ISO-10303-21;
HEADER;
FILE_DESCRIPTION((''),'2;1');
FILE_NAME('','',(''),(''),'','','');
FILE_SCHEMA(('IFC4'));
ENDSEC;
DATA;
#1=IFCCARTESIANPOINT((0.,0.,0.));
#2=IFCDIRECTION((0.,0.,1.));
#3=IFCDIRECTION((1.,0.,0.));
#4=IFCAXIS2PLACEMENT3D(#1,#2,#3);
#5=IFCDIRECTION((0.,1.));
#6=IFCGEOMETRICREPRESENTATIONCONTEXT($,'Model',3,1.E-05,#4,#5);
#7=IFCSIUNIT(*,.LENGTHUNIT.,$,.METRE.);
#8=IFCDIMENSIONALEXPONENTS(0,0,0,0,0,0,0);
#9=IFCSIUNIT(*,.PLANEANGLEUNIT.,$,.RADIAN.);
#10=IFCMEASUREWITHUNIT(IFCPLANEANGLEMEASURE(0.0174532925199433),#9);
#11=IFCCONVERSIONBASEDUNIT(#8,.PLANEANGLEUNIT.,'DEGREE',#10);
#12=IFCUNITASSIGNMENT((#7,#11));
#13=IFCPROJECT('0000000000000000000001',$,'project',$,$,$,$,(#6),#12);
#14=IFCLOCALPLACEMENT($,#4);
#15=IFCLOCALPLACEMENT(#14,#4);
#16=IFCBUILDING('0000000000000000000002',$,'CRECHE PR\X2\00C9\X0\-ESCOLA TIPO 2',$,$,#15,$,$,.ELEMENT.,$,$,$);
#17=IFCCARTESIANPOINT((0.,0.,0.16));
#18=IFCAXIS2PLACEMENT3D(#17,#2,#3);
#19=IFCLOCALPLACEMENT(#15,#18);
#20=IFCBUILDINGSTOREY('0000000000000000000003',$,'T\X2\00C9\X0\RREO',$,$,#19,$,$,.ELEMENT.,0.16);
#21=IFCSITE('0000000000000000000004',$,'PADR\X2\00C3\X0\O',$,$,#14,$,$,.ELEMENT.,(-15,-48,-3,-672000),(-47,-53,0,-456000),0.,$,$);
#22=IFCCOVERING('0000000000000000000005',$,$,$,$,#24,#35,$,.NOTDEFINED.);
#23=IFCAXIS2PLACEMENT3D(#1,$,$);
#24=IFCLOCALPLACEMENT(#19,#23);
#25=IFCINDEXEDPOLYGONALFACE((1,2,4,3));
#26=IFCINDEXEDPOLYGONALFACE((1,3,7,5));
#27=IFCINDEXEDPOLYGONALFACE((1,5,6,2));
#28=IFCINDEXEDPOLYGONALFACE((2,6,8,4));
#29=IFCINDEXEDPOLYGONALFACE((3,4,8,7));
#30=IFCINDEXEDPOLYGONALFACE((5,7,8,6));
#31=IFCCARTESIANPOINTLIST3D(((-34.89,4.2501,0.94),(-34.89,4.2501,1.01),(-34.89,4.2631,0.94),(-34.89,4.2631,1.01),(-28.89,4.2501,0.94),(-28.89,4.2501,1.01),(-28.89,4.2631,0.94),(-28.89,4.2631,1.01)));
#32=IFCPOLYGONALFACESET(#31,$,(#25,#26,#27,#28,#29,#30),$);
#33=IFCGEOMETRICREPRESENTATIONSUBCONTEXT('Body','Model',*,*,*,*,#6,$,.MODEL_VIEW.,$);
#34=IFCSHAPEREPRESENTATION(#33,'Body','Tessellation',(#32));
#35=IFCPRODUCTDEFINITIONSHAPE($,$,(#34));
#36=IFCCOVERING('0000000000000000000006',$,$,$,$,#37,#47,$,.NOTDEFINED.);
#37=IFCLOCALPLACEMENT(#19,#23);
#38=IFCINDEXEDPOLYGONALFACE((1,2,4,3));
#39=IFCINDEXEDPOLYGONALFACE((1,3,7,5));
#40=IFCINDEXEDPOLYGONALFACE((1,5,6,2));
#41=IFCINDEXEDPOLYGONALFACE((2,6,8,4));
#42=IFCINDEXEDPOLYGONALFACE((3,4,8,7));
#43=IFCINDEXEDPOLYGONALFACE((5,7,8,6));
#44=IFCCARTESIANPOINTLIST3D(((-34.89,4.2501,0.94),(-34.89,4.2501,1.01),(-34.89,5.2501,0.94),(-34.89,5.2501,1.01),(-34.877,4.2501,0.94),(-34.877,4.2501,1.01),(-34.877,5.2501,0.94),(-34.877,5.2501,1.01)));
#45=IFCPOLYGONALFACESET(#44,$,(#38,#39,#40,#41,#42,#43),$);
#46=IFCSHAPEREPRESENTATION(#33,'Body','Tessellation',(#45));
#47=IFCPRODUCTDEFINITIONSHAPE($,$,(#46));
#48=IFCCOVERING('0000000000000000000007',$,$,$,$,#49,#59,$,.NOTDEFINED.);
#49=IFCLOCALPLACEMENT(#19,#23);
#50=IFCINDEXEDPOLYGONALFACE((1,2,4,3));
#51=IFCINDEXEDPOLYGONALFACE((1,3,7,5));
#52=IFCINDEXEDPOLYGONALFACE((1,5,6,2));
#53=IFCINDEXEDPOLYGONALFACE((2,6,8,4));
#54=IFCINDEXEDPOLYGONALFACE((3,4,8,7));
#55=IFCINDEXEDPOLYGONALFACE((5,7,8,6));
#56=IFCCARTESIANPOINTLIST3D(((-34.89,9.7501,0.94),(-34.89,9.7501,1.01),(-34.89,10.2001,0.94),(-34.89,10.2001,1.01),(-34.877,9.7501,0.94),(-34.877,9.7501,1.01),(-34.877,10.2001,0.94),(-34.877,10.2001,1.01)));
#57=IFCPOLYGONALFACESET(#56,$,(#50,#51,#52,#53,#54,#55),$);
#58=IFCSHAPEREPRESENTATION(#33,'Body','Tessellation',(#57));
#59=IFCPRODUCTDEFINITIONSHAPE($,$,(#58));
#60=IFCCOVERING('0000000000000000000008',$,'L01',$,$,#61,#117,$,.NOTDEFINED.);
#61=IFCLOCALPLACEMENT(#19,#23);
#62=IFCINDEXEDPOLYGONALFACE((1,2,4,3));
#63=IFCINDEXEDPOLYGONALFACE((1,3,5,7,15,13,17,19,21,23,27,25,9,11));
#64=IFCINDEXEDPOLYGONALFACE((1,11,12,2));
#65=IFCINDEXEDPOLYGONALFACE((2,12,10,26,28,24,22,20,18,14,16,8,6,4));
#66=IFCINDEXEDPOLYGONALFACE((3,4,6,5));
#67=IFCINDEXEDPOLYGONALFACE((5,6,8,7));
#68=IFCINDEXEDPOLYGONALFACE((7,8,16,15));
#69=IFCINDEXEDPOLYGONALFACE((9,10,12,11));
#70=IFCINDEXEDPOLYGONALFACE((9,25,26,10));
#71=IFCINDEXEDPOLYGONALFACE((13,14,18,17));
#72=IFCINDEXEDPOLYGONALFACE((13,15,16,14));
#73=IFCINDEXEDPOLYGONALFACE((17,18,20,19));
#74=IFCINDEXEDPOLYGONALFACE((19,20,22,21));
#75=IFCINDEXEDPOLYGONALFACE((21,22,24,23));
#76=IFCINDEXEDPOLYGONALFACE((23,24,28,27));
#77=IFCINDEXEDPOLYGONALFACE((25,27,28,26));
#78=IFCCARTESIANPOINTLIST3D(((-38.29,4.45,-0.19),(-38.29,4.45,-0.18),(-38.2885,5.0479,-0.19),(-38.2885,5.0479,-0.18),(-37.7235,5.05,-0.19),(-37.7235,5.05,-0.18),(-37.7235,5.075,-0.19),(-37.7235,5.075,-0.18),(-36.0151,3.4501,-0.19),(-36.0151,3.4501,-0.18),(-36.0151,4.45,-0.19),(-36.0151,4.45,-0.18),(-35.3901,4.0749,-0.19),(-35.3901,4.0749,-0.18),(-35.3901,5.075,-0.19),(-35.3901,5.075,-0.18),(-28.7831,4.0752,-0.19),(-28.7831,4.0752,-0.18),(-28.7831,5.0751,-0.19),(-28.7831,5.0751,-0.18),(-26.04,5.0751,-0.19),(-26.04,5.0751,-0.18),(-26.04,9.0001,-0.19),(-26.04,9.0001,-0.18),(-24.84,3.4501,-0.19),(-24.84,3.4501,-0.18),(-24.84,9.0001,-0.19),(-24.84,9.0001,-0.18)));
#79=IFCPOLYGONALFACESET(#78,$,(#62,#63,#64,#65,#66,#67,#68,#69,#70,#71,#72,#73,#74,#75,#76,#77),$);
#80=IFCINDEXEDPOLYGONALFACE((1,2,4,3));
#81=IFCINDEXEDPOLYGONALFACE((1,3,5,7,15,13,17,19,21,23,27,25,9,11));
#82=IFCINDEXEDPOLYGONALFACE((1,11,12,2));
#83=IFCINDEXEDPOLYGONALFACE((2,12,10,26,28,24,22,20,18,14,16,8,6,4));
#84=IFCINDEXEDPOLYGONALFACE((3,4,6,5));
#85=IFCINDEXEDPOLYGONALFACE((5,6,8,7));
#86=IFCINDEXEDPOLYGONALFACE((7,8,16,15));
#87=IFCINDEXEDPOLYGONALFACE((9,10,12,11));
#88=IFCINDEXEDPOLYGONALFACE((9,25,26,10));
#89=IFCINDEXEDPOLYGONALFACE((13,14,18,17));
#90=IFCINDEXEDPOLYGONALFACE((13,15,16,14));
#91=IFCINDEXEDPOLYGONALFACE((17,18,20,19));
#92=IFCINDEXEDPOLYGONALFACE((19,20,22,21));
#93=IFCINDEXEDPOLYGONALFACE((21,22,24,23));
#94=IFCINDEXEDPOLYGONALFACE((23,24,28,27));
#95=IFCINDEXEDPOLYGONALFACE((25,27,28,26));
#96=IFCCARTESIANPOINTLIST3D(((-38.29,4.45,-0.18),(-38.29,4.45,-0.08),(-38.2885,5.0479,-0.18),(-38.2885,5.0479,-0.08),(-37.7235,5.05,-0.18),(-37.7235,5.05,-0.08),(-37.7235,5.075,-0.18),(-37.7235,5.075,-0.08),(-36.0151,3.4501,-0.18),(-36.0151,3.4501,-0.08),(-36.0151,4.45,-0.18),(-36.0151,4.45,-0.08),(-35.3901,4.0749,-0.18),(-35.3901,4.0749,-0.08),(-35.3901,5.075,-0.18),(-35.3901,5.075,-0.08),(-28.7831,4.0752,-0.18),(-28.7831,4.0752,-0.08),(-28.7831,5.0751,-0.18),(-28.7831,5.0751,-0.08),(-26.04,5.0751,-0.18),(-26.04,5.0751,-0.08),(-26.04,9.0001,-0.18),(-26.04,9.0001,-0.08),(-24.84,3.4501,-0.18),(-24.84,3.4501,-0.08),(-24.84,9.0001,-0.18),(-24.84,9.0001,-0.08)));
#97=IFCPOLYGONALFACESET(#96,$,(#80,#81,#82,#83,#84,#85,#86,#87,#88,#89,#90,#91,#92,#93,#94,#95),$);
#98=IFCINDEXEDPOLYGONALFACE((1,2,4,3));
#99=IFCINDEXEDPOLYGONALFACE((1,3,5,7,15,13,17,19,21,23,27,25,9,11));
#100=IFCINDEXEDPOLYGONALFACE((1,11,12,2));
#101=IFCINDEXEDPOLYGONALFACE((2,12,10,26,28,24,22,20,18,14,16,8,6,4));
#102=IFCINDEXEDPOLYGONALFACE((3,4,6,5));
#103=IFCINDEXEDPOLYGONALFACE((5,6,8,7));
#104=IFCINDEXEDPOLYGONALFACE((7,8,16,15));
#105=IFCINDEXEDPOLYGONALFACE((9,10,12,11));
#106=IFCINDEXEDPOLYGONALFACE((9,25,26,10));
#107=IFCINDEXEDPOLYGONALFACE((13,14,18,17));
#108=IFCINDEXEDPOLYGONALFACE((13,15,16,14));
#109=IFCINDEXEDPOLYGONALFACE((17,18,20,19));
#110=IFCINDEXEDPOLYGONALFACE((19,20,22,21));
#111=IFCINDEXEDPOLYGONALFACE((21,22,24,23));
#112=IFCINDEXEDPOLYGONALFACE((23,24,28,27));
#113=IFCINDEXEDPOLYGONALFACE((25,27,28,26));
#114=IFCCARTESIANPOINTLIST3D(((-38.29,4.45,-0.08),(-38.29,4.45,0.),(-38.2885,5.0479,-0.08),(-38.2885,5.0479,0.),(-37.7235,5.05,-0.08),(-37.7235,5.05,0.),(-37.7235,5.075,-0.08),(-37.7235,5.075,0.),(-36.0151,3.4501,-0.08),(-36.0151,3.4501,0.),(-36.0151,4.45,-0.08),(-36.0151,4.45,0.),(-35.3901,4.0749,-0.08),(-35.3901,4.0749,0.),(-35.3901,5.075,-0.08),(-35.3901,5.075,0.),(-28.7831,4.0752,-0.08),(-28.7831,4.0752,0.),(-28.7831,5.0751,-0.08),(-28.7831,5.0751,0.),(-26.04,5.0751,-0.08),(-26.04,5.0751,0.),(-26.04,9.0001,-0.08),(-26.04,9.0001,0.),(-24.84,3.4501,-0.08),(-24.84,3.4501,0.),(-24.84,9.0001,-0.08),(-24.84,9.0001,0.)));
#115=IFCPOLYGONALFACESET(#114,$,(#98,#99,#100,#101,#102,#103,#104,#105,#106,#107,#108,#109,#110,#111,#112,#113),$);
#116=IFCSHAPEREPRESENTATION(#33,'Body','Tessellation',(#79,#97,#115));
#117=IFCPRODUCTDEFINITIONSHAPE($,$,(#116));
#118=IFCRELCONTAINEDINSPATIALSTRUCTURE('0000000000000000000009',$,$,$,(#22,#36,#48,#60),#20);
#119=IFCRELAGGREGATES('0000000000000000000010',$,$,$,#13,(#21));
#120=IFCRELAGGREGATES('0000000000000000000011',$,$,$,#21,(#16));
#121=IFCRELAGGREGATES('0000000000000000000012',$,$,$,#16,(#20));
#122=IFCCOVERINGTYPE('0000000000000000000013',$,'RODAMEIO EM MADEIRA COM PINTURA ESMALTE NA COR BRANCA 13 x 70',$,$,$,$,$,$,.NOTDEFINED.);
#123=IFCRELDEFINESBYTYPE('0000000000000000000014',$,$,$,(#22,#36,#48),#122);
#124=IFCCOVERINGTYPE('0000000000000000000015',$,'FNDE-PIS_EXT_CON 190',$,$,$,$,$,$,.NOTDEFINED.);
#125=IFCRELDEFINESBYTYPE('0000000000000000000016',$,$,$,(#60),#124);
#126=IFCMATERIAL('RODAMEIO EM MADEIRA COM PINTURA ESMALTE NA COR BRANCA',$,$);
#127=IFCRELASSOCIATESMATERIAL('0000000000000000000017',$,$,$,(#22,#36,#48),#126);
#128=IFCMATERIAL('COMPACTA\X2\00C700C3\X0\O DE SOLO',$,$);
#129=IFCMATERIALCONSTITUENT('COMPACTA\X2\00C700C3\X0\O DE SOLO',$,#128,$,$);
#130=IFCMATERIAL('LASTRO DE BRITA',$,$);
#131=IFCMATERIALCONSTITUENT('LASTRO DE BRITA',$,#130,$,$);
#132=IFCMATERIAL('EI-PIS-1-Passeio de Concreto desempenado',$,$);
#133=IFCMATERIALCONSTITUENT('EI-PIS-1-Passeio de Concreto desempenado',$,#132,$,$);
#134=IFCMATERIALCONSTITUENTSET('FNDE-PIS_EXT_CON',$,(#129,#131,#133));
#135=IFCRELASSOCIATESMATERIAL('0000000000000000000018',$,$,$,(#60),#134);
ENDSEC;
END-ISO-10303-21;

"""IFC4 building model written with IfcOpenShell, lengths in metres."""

from ifc_helpers import new_model, entity, si_unit, converted_unit, direction, frame, frame_2d, origin_with_axes, place, context, subcontext, project, spatial, line, indexed_curve, rectangle, outline, extrude, material, constituent, constituent_set, type_object, element, save


model = new_model("IFC4")

# Units and contexts
model_context = context("Model", 3, precision=1e-05, world=origin_with_axes(), true_north=direction((0.0, 1.0)))
body_context = subcontext(model_context, "Body", "Model", "MODEL_VIEW")
ifc_project = project(units=[si_unit("LENGTHUNIT", "METRE"), converted_unit("PLANEANGLEUNIT", "DEGREE", entity("IfcPlaneAngleMeasure", 0.0174532925199433), si_unit("PLANEANGLEUNIT", "RADIAN"), dimensions=[0, 0, 0, 0, 0, 0, 0])], contexts=[model_context])

# Site, building, storey
site_placement = place(None, origin_with_axes())
site = spatial("IfcSite", under=ifc_project, at=site_placement, Name="PADRÃO", CompositionType="ELEMENT", RefLatitude=(-15, -48, -3, -672000), RefLongitude=(-47, -53, 0, -456000), RefElevation=0.0)
building_placement = place(site_placement, origin_with_axes())
building = spatial("IfcBuilding", under=site, at=building_placement, Name="CRECHE PRÉ-ESCOLA TIPO 2", CompositionType="ELEMENT")
storey_placement = place(building_placement, frame((0.0, 0.0, 0.16), z_axis=(0.0, 0.0, 1.0), x_axis=(1.0, 0.0, 0.0)))
storey = spatial("IfcBuildingStorey", under=building, at=storey_placement, Name="TÉRREO", CompositionType="ELEMENT", Elevation=0.16)

# Coverings
ifc_material_1 = material(Name="RODAMEIO EM MADEIRA COM PINTURA ESMALTE NA COR BRANCA")
covering_type_1 = type_object("IfcCoveringType", Name="RODAMEIO EM MADEIRA COM PINTURA ESMALTE NA COR BRANCA 13 x 70", PredefinedType="NOTDEFINED")
covering_1_placement = place(storey_placement, frame((-34.89, 4.2501, 0.94), z_axis=(0.0, 0.0, 1.0), x_axis=(0.0, -1.0, 0.0)))
element("IfcCovering", 1, at=covering_1_placement, inside=storey, type_object=covering_type_1, material=ifc_material_1, PredefinedType="NOTDEFINED", context=body_context, shape_type="SweptSolid", body=[
    extrude(rectangle(XDim=0.07, YDim=0.013, at=frame_2d((0.035, -0.0065), x_axis=(1.0, 0.0))), frame((0.0, 0.0, 0.0), z_axis=(0.0, 1.0, 0.0), x_axis=(0.0, 0.0, 1.0)), (0.0, 0.0, 1.0), 5.9999),
])
covering_2_placement = place(storey_placement, frame((-34.89, 5.2501, 0.94), z_axis=(0.0, 0.0, 1.0), x_axis=(-1.0, 0.0, 0.0)))
element("IfcCovering", 2, at=covering_2_placement, inside=storey, type_object=covering_type_1, material=ifc_material_1, PredefinedType="NOTDEFINED", context=body_context, shape_type="SweptSolid", body=[
    extrude(rectangle(XDim=0.07, YDim=0.013, at=frame_2d((0.035, -0.0065), x_axis=(1.0, 0.0))), frame((0.0, 0.0, 0.0), z_axis=(0.0, 1.0, 0.0), x_axis=(0.0, 0.0, 1.0)), (0.0, 0.0, 1.0), 0.9999),
])
covering_3_placement = place(storey_placement, frame((-34.89, 10.2001, 0.94), z_axis=(0.0, 0.0, 1.0), x_axis=(-1.0, 0.0, 0.0)))
element("IfcCovering", 3, at=covering_3_placement, inside=storey, type_object=covering_type_1, material=ifc_material_1, PredefinedType="NOTDEFINED", context=body_context, shape_type="SweptSolid", body=[
    extrude(rectangle(XDim=0.07, YDim=0.013, at=frame_2d((0.035, -0.0065), x_axis=(1.0, 0.0))), frame((0.0, 0.0, 0.0), z_axis=(0.0, 1.0, 0.0), x_axis=(0.0, 0.0, 1.0)), (0.0, 0.0, 1.0), 0.45),
])
ifc_material_2 = material(Name="COMPACTAÇÃO DE SOLO")
ifc_constituent_1 = constituent(ifc_material_2, Name="COMPACTAÇÃO DE SOLO")
ifc_material_3 = material(Name="LASTRO DE BRITA")
ifc_constituent_2 = constituent(ifc_material_3, Name="LASTRO DE BRITA")
ifc_material_4 = material(Name="EI-PIS-1-Passeio de Concreto desempenado")
ifc_constituent_3 = constituent(ifc_material_4, Name="EI-PIS-1-Passeio de Concreto desempenado")
ifc_constituent_set_1 = constituent_set(constituents=[ifc_constituent_1, ifc_constituent_2, ifc_constituent_3], Name="FNDE-PIS_EXT_CON")
covering_type_2 = type_object("IfcCoveringType", Name="FNDE-PIS_EXT_CON 190", PredefinedType="NOTDEFINED")
covering_4_placement = place(storey_placement, frame((-38.2885, 5.0479, 0.0), z_axis=(0.0, 0.0, 1.0), x_axis=(1.0, 0.0, 0.0)))
element("IfcCovering", 4, at=covering_4_placement, inside=storey, type_object=covering_type_2, material=ifc_constituent_set_1, Name="L01", PredefinedType="NOTDEFINED", context=body_context, shape_type="SweptSolid", body=[
    extrude(outline(indexed_curve([(0.0, 0.0), (-0.0015, -0.598), (2.2734, -0.598), (2.2734, -1.5979), (13.4485, -1.5979), (13.4485, 3.9521), (12.2485, 3.9521), (12.2485, 0.0271), (9.5053, 0.0271), (9.5053, -0.9727), (2.8984, -0.973), (2.8984, 0.027), (0.565, 0.027), (0.565, 0.002)], segments=[line(1, 2, 3, 4, 5, 6, 7, 8, 9, 10, 11, 12, 13, 14, 1)])), frame((0.0, 0.0, -0.19), z_axis=(0.0, 0.0, 1.0), x_axis=(1.0, 0.0, 0.0)), (0.0, 0.0, 1.0), 0.01),
    extrude(outline(indexed_curve([(0.0, 0.0), (-0.0015, -0.598), (2.2734, -0.598), (2.2734, -1.5979), (13.4485, -1.5979), (13.4485, 3.9521), (12.2485, 3.9521), (12.2485, 0.0271), (9.5053, 0.0271), (9.5053, -0.9727), (2.8984, -0.973), (2.8984, 0.027), (0.565, 0.027), (0.565, 0.002)], segments=[line(1, 2, 3, 4, 5, 6, 7, 8, 9, 10, 11, 12, 13, 14, 1)])), frame((0.0, 0.0, -0.18), z_axis=(0.0, 0.0, 1.0), x_axis=(1.0, 0.0, 0.0)), (0.0, 0.0, 1.0), 0.1),
    extrude(outline(indexed_curve([(0.0, 0.0), (-0.0015, -0.598), (2.2734, -0.598), (2.2734, -1.5979), (13.4485, -1.5979), (13.4485, 3.9521), (12.2485, 3.9521), (12.2485, 0.0271), (9.5053, 0.0271), (9.5053, -0.9727), (2.8984, -0.973), (2.8984, 0.027), (0.565, 0.027), (0.565, 0.002)], segments=[line(1, 2, 3, 4, 5, 6, 7, 8, 9, 10, 11, 12, 13, 14, 1)])), frame((0.0, 0.0, -0.08), z_axis=(0.0, 0.0, 1.0), x_axis=(1.0, 0.0, 0.0)), (0.0, 0.0, 1.0), 0.08),
])

save(model, "model.ifc")
